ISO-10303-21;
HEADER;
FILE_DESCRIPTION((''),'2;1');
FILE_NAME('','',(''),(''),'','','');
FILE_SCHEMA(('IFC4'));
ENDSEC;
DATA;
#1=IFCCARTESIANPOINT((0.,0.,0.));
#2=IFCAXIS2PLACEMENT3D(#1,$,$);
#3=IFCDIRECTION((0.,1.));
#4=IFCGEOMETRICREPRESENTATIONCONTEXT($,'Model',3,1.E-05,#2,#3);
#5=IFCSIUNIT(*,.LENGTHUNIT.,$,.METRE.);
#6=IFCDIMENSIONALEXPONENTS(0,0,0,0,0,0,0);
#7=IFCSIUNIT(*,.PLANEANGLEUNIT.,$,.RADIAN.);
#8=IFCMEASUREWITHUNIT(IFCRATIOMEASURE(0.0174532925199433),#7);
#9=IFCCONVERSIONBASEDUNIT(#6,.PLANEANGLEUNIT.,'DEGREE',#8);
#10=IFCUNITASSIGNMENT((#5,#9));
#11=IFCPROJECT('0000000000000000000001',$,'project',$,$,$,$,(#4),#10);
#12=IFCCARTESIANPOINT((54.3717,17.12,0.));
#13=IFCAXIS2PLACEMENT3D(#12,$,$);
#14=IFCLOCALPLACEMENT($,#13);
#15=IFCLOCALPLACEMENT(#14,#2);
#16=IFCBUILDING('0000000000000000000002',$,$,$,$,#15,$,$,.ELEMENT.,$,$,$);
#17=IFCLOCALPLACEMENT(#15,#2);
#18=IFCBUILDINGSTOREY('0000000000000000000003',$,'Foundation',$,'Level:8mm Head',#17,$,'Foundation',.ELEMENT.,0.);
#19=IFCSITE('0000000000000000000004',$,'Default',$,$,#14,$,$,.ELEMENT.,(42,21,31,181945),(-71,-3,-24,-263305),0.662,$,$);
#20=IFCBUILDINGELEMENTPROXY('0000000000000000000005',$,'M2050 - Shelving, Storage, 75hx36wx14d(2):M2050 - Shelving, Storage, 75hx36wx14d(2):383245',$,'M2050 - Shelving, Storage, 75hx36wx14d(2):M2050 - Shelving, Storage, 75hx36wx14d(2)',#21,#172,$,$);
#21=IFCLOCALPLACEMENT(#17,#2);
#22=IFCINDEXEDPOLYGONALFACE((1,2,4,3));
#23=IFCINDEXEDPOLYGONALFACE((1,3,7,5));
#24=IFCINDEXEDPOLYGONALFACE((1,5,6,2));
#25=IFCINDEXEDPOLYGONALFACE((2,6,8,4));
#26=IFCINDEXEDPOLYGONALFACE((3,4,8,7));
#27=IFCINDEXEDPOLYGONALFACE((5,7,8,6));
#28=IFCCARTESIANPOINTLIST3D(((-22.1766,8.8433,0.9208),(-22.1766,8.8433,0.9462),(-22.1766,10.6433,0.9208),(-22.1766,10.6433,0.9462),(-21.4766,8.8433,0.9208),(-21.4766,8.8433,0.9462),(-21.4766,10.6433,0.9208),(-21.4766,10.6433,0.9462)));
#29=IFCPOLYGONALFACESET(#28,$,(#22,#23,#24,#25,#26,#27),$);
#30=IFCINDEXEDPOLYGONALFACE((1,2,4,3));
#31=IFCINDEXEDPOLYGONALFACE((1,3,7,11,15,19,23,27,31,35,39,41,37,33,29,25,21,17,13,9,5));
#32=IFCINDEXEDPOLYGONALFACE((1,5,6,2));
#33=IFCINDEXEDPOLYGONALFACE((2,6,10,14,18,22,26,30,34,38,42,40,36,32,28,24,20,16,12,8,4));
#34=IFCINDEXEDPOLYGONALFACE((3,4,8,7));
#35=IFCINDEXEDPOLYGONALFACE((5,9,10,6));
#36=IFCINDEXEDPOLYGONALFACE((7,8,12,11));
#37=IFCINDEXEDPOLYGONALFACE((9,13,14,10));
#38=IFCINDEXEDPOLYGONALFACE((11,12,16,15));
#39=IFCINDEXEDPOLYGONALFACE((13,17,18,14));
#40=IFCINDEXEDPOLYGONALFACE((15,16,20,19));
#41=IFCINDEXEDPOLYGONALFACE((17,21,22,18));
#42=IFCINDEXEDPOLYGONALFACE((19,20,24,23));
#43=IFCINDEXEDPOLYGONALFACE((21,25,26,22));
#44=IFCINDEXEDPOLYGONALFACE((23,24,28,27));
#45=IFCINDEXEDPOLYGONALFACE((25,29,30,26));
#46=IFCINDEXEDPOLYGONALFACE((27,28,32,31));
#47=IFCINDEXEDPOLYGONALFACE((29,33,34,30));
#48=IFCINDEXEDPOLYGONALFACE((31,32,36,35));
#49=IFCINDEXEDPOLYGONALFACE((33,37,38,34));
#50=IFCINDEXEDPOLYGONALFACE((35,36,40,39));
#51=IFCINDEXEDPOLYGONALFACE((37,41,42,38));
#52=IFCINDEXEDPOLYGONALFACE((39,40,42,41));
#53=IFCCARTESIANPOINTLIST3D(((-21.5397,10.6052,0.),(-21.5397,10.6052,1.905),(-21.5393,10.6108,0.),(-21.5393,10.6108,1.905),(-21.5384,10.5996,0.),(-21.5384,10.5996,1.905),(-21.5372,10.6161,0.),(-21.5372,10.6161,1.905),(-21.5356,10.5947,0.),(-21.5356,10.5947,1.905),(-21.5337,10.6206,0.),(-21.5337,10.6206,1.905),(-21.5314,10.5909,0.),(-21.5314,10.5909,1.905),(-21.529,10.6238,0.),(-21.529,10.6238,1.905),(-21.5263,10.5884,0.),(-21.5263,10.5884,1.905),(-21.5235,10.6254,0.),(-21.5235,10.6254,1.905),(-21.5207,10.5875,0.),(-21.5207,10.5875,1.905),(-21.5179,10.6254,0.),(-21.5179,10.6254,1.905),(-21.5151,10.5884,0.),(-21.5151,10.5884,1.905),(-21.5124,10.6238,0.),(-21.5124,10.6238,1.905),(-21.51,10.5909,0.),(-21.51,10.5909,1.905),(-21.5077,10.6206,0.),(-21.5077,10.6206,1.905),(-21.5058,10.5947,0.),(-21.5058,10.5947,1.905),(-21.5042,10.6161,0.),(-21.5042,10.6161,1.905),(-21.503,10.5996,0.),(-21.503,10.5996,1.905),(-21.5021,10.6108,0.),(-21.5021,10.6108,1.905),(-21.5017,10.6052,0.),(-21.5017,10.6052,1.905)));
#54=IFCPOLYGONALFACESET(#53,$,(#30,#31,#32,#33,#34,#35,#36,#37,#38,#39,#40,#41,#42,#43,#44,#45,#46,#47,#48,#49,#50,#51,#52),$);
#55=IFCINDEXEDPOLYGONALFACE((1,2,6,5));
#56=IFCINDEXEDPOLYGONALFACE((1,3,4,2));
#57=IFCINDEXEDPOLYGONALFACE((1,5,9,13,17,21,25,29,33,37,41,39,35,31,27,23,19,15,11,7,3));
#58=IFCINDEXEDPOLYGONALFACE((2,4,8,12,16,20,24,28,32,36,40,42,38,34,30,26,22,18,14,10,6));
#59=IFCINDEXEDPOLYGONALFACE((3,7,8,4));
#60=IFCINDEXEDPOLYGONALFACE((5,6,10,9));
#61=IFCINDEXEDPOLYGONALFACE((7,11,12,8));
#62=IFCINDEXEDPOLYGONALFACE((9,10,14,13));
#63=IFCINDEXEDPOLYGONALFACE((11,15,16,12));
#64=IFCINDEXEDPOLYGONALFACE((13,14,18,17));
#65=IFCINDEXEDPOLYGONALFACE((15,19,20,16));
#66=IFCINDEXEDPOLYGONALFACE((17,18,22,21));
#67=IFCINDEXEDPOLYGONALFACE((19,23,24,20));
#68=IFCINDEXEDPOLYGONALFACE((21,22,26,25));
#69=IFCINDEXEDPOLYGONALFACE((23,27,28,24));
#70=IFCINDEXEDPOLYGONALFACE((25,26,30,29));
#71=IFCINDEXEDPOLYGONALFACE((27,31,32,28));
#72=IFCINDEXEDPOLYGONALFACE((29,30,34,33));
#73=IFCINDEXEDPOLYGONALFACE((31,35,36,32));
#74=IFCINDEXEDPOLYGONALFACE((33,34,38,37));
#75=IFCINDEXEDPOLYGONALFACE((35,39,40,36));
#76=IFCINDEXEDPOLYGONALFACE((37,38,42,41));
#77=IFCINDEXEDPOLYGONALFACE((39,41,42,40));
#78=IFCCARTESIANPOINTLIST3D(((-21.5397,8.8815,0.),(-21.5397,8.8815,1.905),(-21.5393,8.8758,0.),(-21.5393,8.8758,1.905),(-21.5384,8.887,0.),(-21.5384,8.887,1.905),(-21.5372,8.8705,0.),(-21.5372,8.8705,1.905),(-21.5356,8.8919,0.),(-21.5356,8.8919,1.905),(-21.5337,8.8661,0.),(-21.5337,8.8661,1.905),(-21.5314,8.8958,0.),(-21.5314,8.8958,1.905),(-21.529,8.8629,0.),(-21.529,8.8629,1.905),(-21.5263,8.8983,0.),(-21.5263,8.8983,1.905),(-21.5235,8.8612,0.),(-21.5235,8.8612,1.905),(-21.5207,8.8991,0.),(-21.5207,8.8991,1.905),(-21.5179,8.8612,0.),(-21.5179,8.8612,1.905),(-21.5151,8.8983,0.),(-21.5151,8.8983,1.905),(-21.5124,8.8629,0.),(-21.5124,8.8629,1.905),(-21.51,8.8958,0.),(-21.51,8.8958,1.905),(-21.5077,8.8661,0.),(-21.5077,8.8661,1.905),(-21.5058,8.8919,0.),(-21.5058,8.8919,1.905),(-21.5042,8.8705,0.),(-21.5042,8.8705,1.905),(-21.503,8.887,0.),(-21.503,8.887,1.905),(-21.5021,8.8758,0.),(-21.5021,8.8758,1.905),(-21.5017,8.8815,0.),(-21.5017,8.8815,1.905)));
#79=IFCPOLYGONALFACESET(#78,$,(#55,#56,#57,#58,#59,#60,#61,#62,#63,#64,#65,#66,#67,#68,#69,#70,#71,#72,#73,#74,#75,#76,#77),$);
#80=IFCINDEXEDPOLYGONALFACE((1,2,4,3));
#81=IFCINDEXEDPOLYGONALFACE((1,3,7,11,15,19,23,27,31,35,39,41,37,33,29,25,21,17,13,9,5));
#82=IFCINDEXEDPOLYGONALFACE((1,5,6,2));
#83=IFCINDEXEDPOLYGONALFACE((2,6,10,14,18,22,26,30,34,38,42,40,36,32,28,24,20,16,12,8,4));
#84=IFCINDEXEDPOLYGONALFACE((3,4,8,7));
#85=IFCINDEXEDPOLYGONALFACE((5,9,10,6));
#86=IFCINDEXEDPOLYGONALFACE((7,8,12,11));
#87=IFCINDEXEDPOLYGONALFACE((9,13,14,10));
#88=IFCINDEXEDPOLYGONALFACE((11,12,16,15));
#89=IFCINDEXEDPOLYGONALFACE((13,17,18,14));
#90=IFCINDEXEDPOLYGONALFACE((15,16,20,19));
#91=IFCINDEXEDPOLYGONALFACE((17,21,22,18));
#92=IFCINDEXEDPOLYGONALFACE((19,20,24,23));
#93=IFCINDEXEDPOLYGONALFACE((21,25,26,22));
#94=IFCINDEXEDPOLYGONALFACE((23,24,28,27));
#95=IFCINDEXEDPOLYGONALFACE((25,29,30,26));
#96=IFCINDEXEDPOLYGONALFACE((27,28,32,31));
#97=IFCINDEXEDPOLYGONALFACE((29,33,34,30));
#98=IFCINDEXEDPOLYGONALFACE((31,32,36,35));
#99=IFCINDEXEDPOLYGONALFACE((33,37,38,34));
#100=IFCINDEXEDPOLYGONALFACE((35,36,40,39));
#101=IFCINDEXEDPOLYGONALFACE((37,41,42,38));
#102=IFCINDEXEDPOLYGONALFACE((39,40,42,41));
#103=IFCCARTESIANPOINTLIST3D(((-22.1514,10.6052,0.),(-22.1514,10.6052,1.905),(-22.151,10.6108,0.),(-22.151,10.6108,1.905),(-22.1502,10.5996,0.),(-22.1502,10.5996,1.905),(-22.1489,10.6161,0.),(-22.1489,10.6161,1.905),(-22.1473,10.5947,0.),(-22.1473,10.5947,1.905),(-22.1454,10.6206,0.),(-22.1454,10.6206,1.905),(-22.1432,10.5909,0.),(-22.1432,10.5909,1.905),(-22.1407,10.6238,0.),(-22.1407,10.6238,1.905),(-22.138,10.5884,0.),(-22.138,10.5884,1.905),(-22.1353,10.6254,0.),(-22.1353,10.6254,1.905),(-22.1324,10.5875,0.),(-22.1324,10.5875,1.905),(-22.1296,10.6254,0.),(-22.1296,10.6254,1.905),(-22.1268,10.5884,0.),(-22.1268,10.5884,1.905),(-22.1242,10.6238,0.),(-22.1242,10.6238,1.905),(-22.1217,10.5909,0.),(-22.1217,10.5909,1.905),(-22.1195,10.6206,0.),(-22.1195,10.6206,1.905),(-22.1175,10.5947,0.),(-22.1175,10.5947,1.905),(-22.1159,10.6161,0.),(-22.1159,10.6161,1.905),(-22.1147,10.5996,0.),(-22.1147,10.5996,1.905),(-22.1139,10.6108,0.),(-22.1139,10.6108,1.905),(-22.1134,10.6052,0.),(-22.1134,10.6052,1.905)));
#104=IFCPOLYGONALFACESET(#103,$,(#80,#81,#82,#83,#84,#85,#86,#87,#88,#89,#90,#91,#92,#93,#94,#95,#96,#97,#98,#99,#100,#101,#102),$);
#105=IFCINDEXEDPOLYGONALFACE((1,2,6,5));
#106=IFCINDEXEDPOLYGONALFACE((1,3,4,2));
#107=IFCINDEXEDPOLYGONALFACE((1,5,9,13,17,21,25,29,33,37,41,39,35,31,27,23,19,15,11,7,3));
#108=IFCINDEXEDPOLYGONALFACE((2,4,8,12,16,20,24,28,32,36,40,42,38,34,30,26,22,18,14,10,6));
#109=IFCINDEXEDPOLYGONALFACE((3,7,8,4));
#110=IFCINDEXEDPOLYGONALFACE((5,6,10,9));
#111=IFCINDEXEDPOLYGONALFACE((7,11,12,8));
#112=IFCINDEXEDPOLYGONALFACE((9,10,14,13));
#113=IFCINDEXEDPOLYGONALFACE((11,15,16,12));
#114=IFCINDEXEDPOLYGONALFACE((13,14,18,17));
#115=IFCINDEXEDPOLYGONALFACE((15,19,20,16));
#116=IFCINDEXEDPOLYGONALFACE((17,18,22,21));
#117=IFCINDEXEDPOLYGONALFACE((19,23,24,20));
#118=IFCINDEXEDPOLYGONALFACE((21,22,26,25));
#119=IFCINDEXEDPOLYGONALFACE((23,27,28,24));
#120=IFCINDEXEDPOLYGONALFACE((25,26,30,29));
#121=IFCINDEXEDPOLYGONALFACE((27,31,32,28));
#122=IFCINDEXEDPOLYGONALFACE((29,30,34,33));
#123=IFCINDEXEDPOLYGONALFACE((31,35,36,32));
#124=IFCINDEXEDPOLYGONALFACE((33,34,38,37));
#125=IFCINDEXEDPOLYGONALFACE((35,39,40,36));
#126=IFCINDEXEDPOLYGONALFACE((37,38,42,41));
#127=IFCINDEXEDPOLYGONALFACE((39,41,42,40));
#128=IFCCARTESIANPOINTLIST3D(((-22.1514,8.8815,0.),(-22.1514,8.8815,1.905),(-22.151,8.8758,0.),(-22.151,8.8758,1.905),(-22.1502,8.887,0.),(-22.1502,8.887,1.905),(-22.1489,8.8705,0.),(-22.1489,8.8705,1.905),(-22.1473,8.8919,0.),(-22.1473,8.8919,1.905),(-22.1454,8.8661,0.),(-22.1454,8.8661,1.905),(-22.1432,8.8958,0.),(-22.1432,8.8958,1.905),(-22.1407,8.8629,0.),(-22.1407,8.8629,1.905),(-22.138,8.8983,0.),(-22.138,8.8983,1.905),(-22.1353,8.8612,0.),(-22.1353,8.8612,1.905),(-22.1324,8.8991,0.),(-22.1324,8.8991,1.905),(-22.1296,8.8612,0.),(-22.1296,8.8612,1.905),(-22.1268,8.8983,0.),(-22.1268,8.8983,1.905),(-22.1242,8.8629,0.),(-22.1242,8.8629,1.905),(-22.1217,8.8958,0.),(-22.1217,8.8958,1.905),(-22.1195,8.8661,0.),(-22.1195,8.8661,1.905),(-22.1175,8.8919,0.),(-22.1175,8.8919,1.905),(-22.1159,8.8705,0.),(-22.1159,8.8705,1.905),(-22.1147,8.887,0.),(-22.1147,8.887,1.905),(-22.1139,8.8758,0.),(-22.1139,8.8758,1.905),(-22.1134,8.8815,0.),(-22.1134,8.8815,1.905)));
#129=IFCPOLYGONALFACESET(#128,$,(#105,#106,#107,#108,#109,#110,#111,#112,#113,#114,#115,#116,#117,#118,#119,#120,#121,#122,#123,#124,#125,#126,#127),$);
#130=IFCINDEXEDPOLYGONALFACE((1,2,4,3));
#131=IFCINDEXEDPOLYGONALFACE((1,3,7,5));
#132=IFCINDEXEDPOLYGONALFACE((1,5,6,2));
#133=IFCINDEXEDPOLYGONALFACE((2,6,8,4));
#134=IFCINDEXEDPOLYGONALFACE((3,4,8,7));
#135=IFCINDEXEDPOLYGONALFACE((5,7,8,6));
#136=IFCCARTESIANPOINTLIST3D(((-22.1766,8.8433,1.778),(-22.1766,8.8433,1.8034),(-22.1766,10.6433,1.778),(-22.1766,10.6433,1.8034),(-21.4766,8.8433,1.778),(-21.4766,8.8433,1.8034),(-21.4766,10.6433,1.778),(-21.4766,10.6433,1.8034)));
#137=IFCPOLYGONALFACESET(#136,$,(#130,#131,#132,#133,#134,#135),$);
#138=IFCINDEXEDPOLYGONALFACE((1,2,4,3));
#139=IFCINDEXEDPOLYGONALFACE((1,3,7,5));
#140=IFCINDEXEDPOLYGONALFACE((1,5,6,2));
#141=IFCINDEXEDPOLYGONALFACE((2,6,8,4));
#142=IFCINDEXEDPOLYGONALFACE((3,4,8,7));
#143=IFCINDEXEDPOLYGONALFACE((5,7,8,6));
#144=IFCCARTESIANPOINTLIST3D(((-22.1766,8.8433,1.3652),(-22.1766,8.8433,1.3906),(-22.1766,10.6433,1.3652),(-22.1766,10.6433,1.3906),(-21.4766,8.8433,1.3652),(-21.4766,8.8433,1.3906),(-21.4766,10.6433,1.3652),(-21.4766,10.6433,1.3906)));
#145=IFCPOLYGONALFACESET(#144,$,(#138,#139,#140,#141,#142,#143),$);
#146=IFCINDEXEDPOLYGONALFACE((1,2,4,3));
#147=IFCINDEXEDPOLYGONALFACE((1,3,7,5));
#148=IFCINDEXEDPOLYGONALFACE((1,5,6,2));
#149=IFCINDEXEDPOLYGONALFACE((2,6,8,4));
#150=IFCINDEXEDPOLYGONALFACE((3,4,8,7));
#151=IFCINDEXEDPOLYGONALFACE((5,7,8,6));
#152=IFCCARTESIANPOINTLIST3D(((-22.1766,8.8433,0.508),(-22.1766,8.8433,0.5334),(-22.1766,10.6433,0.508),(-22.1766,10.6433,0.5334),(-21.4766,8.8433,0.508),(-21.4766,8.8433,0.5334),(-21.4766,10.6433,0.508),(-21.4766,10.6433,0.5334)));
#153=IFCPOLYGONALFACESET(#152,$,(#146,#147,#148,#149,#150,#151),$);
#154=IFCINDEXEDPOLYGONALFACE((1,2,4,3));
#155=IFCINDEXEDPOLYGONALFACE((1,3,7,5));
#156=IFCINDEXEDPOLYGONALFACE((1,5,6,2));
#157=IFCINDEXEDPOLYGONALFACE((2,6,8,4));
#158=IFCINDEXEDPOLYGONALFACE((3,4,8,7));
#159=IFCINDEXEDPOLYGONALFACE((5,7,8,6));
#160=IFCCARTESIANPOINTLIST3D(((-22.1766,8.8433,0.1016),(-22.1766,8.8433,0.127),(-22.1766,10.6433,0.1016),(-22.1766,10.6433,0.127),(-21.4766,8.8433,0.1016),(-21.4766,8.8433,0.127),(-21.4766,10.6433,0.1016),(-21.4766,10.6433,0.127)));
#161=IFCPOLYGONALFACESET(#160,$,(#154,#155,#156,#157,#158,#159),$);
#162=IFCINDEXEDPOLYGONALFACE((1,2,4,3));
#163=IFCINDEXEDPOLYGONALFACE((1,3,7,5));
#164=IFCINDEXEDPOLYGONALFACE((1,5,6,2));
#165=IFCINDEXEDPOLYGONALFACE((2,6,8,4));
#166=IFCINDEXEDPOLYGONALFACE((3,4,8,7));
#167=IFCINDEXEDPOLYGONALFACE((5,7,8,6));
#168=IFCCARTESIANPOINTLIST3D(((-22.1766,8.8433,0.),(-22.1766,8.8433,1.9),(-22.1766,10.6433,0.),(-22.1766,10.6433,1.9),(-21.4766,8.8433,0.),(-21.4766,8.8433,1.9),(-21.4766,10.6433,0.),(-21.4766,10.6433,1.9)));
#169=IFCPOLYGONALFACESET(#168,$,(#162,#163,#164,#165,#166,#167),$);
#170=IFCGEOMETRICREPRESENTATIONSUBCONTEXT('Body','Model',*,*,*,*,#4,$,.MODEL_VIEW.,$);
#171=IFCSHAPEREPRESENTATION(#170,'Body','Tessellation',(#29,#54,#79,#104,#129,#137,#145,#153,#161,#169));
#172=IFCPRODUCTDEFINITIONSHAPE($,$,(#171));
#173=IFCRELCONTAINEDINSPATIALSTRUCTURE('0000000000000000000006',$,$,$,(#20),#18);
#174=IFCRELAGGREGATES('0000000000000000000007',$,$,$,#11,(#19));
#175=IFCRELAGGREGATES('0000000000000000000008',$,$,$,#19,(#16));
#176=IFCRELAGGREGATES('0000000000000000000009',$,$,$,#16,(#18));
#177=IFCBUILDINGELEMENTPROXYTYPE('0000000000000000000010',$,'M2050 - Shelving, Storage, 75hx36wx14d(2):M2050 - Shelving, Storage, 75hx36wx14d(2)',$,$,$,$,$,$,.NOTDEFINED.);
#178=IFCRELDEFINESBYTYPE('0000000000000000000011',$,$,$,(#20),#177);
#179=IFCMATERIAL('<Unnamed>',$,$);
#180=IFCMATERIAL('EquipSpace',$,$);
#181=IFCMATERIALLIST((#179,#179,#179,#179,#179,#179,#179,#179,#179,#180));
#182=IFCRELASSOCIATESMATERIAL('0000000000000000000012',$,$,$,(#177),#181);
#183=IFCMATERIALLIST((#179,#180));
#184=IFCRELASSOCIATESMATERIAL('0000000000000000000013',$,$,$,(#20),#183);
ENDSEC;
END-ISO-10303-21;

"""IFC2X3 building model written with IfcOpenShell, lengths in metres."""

from ifc_helpers import new_model, entity, si_unit, converted_unit, direction, frame, frame_2d, origin, origin_2d_with_axis, place, context, subcontext, project, spatial, rectangle, circle, extrude, source, transform, mapped, material, material_list, type_object, type_shapes, element, save


model = new_model("IFC2X3")

# Units and contexts
model_context = context("Model", 3, precision=1e-05, world=origin(), true_north=direction((0.0, 1.0)))
body_context = subcontext(model_context, "Body", "Model", "MODEL_VIEW")
ifc_project = project(units=[si_unit("LENGTHUNIT", "METRE"), converted_unit("PLANEANGLEUNIT", "DEGREE", entity("IfcRatioMeasure", 0.0174532925199433), si_unit("PLANEANGLEUNIT", "RADIAN"), dimensions=[0, 0, 0, 0, 0, 0, 0])], contexts=[model_context])

# Site, building, storey
site_placement = place(None, frame((54.3717, 17.12, 0.0)))
site = spatial("IfcSite", under=ifc_project, at=site_placement, Name="Default", CompositionType="ELEMENT", RefLatitude=(42, 21, 31, 181945), RefLongitude=(-71, -3, -24, -263305), RefElevation=0.662)
building_placement = place(site_placement, origin())
building = spatial("IfcBuilding", under=site, at=building_placement, CompositionType="ELEMENT")
storey_placement = place(building_placement, origin())
storey = spatial("IfcBuildingStorey", under=building, at=storey_placement, Name="Foundation", ObjectType="Level:8mm Head", LongName="Foundation", CompositionType="ELEMENT", Elevation=0.0)

# Building element proxy
ifc_material_1 = material(Name="<Unnamed>")
ifc_material_2 = material(Name="EquipSpace")
ifc_material_list_1 = material_list([ifc_material_1, ifc_material_1, ifc_material_1, ifc_material_1, ifc_material_1, ifc_material_1, ifc_material_1, ifc_material_1, ifc_material_1, ifc_material_2])
building_element_proxy_type = type_object("IfcBuildingElementProxyType", Name="M2050 - Shelving, Storage, 75hx36wx14d(2):M2050 - Shelving, Storage, 75hx36wx14d(2)", PredefinedType="NOTDEFINED", material=ifc_material_list_1)
shared_shape = source(origin(), body_context, "Body", "SweptSolid", [
    extrude(rectangle(XDim=1.8, YDim=0.7, at=origin_2d_with_axis()), frame((0.0, 0.0, 0.9207), z_axis=(0.0, 0.0, 1.0), x_axis=(-1.0, 0.0, 0.0)), (0.0, 0.0, 1.0), 0.0254),
    extrude(circle(Radius=0.0191, at=origin_2d_with_axis()), frame((0.8633, -0.3059, 0.0), z_axis=(0.0, 0.0, 1.0), x_axis=(-1.0, 0.0, 0.0)), (0.0, 0.0, 1.0), 1.905),
    extrude(circle(Radius=0.0191, at=origin_2d_with_axis()), frame((-0.8633, -0.3059, 0.0)), (0.0, 0.0, 1.0), 1.905),
    extrude(circle(Radius=0.0191, at=origin_2d_with_axis()), frame((0.8633, 0.3059, 0.0), z_axis=(0.0, 0.0, 1.0), x_axis=(-1.0, 0.0, 0.0)), (0.0, 0.0, 1.0), 1.905),
    extrude(circle(Radius=0.0191, at=origin_2d_with_axis()), frame((-0.8633, 0.3059, 0.0)), (0.0, 0.0, 1.0), 1.905),
    extrude(rectangle(XDim=1.8, YDim=0.7, at=origin_2d_with_axis()), frame((0.0, 0.0, 1.778), z_axis=(0.0, 0.0, 1.0), x_axis=(-1.0, 0.0, 0.0)), (0.0, 0.0, 1.0), 0.0254),
    extrude(rectangle(XDim=1.8, YDim=0.7, at=origin_2d_with_axis()), frame((0.0, 0.0, 1.3653), z_axis=(0.0, 0.0, 1.0), x_axis=(-1.0, 0.0, 0.0)), (0.0, 0.0, 1.0), 0.0254),
    extrude(rectangle(XDim=1.8, YDim=0.7, at=origin_2d_with_axis()), frame((0.0, 0.0, 0.508), z_axis=(0.0, 0.0, 1.0), x_axis=(-1.0, 0.0, 0.0)), (0.0, 0.0, 1.0), 0.0254),
    extrude(rectangle(XDim=1.8, YDim=0.7, at=origin_2d_with_axis()), frame((0.0, 0.0, 0.1016), z_axis=(0.0, 0.0, 1.0), x_axis=(-1.0, 0.0, 0.0)), (0.0, 0.0, 1.0), 0.0254),
    extrude(rectangle(XDim=0.7, YDim=1.8, at=frame_2d((0.0, 0.18), x_axis=(1.0, 0.0))), frame((-0.18, 0.0, 0.0), z_axis=(0.0, 0.0, 1.0), x_axis=(0.0, -1.0, 0.0)), (0.0, 0.0, 1.0), 1.9),
])
type_shapes(building_element_proxy_type, [shared_shape])
ifc_material_list_2 = material_list([ifc_material_1, ifc_material_2])
proxy_1_placement = place(storey_placement, frame((-21.8266, 9.7433, 0.0), z_axis=(0.0, 0.0, 1.0), x_axis=(0.0, 1.0, 0.0)))
element("IfcBuildingElementProxy", 1, at=proxy_1_placement, inside=storey, type_object=building_element_proxy_type, material=ifc_material_list_2, Name="M2050 - Shelving, Storage, 75hx36wx14d(2):M2050 - Shelving, Storage, 75hx36wx14d(2):383245", ObjectType="M2050 - Shelving, Storage, 75hx36wx14d(2):M2050 - Shelving, Storage, 75hx36wx14d(2)", context=body_context, shape_type="MappedRepresentation", body=[
    mapped(shared_shape, transform((0.0, 0.0, 0.0), scale=1.0)),
])

save(model, "model.ifc")
